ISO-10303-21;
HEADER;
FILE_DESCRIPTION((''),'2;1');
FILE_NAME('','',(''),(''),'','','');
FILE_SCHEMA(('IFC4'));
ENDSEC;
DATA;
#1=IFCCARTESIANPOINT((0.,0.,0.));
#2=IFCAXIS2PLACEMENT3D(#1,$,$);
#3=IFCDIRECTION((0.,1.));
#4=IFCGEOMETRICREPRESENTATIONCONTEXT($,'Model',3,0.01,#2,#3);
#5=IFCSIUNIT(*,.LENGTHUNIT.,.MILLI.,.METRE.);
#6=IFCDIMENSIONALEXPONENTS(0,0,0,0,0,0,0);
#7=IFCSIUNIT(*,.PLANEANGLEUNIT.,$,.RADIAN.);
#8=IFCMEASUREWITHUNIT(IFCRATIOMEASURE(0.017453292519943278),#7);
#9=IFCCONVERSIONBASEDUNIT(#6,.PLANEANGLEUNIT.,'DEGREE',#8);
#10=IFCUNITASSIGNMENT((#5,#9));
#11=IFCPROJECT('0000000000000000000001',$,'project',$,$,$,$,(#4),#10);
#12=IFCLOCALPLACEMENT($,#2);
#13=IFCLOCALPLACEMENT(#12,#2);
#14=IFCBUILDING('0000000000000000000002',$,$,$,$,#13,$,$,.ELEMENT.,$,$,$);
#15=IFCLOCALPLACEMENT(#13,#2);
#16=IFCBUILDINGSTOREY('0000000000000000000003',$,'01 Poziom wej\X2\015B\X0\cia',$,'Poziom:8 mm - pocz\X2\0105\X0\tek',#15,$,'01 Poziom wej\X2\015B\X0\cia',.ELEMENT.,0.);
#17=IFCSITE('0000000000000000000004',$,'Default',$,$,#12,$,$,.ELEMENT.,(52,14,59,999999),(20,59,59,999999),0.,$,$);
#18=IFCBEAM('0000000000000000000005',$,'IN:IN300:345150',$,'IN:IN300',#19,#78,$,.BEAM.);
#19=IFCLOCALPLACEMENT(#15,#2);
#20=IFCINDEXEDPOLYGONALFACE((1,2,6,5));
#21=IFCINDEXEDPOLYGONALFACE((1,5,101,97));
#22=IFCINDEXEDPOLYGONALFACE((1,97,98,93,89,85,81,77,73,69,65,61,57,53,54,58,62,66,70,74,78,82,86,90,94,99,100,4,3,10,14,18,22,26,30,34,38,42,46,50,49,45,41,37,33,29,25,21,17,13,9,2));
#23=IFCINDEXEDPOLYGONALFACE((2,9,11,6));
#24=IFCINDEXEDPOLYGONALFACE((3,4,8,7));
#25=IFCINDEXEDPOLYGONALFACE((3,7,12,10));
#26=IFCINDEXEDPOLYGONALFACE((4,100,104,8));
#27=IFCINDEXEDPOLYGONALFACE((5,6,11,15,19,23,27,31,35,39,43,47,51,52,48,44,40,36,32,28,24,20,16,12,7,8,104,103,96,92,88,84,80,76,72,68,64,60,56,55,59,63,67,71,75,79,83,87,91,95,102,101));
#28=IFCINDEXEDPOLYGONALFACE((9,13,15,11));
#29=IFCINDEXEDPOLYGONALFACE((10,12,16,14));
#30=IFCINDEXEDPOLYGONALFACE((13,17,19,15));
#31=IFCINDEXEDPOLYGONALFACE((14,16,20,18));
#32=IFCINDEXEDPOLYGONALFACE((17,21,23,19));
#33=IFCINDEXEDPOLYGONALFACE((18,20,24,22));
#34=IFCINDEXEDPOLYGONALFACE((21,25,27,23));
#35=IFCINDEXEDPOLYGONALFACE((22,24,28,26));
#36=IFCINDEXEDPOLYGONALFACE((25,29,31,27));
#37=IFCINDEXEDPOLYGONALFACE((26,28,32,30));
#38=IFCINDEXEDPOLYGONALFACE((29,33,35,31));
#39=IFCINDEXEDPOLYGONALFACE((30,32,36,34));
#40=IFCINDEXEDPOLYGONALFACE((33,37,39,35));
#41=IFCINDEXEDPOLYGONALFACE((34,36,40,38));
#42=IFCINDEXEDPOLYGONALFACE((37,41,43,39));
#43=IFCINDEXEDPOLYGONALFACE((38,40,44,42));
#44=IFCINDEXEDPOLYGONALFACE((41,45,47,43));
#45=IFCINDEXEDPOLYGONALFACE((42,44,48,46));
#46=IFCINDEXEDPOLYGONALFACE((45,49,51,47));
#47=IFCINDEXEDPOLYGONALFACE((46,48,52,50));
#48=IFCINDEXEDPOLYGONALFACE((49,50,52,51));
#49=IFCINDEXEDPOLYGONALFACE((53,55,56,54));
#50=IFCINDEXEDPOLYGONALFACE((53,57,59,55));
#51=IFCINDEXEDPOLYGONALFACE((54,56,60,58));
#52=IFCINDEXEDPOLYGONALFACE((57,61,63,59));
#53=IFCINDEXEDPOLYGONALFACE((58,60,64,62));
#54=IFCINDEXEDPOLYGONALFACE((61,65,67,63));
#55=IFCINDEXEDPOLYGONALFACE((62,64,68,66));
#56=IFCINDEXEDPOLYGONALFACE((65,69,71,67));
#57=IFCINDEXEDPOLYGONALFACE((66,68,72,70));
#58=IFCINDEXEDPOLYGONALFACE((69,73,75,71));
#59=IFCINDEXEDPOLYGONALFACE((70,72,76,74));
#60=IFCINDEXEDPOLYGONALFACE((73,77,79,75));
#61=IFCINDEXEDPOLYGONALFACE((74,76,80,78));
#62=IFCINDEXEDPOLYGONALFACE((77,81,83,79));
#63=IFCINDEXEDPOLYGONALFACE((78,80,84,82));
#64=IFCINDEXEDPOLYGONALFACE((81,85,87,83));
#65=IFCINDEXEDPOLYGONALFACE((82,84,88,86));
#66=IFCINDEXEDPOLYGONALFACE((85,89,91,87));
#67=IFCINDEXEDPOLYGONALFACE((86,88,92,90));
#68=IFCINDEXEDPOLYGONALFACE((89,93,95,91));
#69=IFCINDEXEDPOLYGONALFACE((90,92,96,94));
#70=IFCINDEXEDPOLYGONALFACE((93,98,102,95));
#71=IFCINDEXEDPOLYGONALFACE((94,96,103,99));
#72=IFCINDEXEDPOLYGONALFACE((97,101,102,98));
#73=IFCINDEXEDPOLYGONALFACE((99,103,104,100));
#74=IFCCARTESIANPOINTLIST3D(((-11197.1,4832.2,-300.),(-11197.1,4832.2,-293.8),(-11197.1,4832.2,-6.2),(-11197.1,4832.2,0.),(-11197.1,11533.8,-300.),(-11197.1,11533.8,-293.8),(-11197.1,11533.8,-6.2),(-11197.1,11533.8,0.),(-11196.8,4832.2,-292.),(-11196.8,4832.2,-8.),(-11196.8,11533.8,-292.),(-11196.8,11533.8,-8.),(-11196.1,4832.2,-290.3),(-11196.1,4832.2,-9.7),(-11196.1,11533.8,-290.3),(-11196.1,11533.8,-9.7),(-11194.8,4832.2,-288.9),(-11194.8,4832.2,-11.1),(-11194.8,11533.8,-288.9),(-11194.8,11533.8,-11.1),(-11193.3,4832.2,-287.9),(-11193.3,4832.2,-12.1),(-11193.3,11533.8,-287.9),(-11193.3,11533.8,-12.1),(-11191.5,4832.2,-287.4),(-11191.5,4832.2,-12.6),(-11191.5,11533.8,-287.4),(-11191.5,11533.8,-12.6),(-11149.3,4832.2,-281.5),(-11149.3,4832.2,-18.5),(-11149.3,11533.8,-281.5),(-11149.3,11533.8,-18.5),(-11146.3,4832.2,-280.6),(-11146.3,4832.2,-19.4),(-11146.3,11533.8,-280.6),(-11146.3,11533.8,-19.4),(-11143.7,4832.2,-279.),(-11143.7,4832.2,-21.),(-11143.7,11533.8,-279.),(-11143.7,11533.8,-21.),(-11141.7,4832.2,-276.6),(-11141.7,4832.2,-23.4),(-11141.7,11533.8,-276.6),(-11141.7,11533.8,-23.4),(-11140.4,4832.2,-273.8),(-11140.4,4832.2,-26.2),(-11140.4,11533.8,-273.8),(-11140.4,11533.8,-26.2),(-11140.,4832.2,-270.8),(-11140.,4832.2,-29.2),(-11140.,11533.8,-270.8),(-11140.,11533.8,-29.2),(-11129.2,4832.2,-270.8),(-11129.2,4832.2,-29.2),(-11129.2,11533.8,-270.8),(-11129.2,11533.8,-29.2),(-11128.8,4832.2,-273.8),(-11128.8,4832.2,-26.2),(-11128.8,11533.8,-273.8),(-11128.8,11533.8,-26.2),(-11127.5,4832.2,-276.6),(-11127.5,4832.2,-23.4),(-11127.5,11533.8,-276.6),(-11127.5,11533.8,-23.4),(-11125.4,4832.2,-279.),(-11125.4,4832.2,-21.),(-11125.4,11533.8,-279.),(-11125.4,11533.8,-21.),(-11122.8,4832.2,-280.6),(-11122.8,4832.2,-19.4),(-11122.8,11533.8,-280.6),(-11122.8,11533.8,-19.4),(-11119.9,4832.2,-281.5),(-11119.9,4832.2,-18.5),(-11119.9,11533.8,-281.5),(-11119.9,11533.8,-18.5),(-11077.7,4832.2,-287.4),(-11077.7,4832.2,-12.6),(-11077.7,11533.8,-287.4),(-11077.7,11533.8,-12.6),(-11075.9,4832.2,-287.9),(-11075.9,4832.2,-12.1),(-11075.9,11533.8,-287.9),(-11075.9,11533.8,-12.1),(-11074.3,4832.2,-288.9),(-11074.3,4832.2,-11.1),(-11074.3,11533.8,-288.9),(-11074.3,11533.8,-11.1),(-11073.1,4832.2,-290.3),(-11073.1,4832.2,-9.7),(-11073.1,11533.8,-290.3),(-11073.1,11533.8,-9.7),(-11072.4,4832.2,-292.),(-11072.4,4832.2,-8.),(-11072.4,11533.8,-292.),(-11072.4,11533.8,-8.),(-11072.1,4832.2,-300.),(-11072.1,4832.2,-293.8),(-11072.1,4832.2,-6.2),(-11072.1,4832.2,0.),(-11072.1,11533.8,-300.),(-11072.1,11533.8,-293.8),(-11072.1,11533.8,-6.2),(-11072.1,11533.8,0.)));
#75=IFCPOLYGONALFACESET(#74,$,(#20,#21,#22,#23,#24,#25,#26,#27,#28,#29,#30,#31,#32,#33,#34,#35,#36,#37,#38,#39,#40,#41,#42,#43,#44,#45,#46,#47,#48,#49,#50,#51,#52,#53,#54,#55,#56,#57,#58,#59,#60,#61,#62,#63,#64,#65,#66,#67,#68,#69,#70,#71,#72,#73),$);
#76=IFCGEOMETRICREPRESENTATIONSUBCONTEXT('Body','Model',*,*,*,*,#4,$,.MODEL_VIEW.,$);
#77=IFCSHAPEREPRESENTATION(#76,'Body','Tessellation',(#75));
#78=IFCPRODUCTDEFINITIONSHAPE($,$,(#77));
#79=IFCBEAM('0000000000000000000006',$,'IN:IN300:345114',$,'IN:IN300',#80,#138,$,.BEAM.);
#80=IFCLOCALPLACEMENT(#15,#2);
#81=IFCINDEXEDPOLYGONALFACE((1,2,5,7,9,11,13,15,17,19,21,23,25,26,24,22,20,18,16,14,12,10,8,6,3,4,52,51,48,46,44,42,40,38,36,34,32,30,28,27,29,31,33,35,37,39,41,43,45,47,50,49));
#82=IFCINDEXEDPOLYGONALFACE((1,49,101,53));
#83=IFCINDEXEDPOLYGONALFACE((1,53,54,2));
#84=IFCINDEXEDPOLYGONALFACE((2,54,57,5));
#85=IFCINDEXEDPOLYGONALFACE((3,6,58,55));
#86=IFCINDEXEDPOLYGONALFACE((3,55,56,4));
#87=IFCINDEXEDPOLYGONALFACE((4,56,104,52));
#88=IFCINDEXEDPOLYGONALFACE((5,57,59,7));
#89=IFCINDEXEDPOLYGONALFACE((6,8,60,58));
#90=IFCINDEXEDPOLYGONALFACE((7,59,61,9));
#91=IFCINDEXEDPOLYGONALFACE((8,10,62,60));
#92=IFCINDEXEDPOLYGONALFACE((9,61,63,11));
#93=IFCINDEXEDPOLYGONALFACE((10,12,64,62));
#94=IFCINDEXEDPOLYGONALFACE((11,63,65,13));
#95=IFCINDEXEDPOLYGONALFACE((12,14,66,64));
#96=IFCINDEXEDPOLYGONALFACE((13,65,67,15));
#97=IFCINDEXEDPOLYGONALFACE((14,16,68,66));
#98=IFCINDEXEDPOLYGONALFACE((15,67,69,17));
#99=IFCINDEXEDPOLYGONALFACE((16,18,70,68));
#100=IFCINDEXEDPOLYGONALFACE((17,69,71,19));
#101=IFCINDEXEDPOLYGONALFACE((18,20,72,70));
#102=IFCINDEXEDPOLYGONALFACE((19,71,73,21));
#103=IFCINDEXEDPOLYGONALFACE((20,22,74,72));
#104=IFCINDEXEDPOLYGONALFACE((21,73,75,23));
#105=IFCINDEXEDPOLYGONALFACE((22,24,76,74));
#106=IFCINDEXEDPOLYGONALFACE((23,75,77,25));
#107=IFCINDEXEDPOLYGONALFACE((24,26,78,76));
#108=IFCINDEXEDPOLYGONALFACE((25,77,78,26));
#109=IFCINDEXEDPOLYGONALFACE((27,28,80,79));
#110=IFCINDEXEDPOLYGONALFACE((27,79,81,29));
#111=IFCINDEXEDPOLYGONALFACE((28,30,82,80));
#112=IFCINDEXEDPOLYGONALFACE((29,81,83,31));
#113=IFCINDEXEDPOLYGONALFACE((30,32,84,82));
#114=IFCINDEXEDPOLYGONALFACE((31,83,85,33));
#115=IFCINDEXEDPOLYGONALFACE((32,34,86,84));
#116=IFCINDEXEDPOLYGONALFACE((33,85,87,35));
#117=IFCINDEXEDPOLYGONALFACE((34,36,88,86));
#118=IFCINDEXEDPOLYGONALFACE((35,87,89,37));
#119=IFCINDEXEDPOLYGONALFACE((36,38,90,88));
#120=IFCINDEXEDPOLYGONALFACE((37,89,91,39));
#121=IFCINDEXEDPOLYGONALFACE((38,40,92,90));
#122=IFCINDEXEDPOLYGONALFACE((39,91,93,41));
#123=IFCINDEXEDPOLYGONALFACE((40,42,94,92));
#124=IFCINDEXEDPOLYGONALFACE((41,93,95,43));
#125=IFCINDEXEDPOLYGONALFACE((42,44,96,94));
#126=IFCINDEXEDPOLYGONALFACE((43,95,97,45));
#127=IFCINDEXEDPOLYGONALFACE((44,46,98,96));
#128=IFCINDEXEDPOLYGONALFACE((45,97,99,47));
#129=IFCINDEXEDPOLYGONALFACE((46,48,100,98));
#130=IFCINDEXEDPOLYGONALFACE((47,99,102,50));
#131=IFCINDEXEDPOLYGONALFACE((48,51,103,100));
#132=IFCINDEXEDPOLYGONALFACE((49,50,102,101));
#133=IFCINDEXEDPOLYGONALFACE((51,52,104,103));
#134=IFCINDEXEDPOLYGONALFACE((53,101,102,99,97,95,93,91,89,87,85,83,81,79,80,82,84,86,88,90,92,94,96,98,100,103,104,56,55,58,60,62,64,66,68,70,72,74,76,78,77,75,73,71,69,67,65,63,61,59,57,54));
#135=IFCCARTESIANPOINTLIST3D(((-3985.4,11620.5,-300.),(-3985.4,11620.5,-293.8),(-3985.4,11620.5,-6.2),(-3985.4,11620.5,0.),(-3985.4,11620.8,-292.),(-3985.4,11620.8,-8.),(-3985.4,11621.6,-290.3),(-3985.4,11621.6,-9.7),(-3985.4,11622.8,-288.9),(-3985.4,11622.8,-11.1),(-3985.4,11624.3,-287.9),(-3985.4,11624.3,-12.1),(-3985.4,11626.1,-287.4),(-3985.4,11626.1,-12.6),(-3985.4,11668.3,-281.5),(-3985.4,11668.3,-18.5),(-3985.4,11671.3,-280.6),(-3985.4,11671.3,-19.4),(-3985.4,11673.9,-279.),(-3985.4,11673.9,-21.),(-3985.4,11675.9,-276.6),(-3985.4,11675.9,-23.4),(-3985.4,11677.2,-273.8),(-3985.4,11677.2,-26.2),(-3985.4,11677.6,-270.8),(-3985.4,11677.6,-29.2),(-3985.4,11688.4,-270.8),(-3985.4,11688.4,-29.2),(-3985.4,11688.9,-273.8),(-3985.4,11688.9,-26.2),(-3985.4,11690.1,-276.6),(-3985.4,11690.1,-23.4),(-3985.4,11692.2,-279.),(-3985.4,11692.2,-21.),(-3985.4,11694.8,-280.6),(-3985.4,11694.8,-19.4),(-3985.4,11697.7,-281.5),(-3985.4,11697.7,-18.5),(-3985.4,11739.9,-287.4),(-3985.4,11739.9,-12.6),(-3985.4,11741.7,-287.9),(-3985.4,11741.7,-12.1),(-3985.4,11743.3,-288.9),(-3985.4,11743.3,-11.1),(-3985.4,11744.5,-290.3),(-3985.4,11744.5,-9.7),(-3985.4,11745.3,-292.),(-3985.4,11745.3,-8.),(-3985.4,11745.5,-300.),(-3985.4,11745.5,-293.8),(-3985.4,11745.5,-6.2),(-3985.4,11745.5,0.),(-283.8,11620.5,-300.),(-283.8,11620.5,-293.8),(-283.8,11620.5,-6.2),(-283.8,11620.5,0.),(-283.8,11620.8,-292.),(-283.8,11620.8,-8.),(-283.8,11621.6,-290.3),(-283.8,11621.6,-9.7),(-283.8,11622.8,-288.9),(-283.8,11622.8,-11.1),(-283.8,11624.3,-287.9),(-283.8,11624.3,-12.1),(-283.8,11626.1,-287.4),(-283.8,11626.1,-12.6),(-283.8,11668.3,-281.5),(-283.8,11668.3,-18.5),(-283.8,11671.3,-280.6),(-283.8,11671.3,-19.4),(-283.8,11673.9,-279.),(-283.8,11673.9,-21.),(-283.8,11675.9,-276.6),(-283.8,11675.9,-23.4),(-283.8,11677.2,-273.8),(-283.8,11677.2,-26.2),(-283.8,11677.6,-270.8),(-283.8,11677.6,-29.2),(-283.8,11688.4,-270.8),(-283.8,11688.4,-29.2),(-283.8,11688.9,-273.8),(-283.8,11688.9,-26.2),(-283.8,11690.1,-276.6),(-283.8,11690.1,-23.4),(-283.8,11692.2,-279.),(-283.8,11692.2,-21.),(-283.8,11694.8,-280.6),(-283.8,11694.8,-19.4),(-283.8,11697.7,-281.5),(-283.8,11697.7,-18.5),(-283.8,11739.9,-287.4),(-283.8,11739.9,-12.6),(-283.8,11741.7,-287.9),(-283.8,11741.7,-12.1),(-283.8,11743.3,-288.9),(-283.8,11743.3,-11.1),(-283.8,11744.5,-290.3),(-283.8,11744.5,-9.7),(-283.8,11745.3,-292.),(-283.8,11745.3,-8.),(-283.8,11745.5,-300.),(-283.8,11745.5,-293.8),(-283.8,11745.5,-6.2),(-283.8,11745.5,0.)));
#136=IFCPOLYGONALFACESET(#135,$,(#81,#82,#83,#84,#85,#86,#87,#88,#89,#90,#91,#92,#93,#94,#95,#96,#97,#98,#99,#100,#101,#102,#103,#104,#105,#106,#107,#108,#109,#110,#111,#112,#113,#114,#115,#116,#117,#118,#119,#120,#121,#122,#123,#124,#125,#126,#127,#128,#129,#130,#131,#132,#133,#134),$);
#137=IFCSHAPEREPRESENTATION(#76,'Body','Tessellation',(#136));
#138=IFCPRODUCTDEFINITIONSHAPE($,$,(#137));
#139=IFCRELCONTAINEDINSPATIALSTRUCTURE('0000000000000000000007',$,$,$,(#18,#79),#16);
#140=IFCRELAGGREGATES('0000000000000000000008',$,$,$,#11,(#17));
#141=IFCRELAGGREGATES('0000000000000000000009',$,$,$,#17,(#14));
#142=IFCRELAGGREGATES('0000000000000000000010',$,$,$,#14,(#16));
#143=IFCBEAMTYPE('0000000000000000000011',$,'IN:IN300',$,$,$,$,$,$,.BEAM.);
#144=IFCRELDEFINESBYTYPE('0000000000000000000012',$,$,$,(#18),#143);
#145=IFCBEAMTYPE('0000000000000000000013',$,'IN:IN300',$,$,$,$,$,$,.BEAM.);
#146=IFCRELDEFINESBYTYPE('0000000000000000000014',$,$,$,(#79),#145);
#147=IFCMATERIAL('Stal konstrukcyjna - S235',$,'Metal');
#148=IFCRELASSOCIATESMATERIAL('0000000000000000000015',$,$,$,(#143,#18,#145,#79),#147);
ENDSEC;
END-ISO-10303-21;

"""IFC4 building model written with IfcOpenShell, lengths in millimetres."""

from ifc_helpers import new_model, entity, si_unit, converted_unit, direction, frame, origin, place, context, subcontext, project, spatial, line, arc, indexed_curve, outline, extrude, source, transform, mapped, material, type_object, type_shapes, element, save


model = new_model("IFC4")

# Units and contexts
model_context = context("Model", 3, precision=0.01, world=origin(), true_north=direction((0.0, 1.0)))
body_context = subcontext(model_context, "Body", "Model", "MODEL_VIEW")
ifc_project = project(units=[si_unit("LENGTHUNIT", "METRE", prefix="MILLI"), converted_unit("PLANEANGLEUNIT", "DEGREE", entity("IfcRatioMeasure", 0.017453292519943278), si_unit("PLANEANGLEUNIT", "RADIAN"), dimensions=[0, 0, 0, 0, 0, 0, 0])], contexts=[model_context])

# Site, building, storey
site_placement = place(None, origin())
site = spatial("IfcSite", under=ifc_project, at=site_placement, Name="Default", CompositionType="ELEMENT", RefLatitude=(52, 14, 59, 999999), RefLongitude=(20, 59, 59, 999999), RefElevation=0.0)
building_placement = place(site_placement, origin())
building = spatial("IfcBuilding", under=site, at=building_placement, CompositionType="ELEMENT")
storey_placement = place(building_placement, origin())
storey = spatial("IfcBuildingStorey", under=building, at=storey_placement, Name="01 Poziom wejścia", ObjectType="Poziom:8 mm - początek", LongName="01 Poziom wejścia", CompositionType="ELEMENT", Elevation=0.0)

# Beams
ifc_material = material(Name="Stal konstrukcyjna - S235", Category="Metal")
beam_type_1 = type_object("IfcBeamType", Name="IN:IN300", PredefinedType="BEAM", material=ifc_material)
shared_shape_1 = source(origin(), body_context, "Body", "SweptSolid", [
    extrude(outline(indexed_curve([(143.8, -62.5), (150.0, -62.5), (150.0, 62.5), (143.8, 62.5), (139.6, 60.9), (137.4, 56.9), (131.5, 14.7), (127.9, 8.1), (120.8, 5.4), (-120.8, 5.4), (-127.9, 8.1), (-131.5, 14.7), (-137.4, 56.9), (-139.6, 60.9), (-143.8, 62.5), (-150.0, 62.5), (-150.0, -62.5), (-143.8, -62.5), (-139.6, -60.9), (-137.4, -56.9), (-131.5, -14.7), (-127.9, -8.1), (-120.8, -5.4), (120.8, -5.4), (127.9, -8.1), (131.5, -14.7), (137.4, -56.9), (139.6, -60.9)], segments=[line(1, 2, 3, 4), arc(4, 5, 6), line(6, 7), arc(7, 8, 9), line(9, 10), arc(10, 11, 12), line(12, 13), arc(13, 14, 15), line(15, 16, 17, 18), arc(18, 19, 20), line(20, 21), arc(21, 22, 23), line(23, 24), arc(24, 25, 26), line(26, 27), arc(27, 28, 1)], self_intersect=False)), frame((-3350.8, 0.0, 0.0), z_axis=(1.0, 0.0, 0.0), x_axis=(0.0, 0.0, -1.0)), (0.0, 0.0, 1.0), 6701.6),
])
type_shapes(beam_type_1, [shared_shape_1])
for number, where, z_axis, x_axis, name in (
    (1, (-11134.6, 8183.0, -150.0), (0.0, 0.0, 1.0), (0.0, -1.0, 0.0), "IN:IN300:345150"),
):
    element("IfcBeam", number, at=place(storey_placement, frame(where, z_axis=z_axis, x_axis=x_axis)), inside=storey, type_object=beam_type_1, material=ifc_material, Name=name, ObjectType="IN:IN300", PredefinedType="BEAM", context=body_context, shape_type="MappedRepresentation", body=[
        mapped(shared_shape_1, transform((0.0, 0.0, 0.0), scale=1.0)),
    ])
beam_type_2 = type_object("IfcBeamType", Name="IN:IN300", PredefinedType="BEAM", material=ifc_material)
shared_shape_2 = source(origin(), body_context, "Body", "SweptSolid", [
    extrude(outline(indexed_curve([(143.8, -62.5), (150.0, -62.5), (150.0, 62.5), (143.8, 62.5), (139.6, 60.9), (137.4, 56.9), (131.5, 14.7), (127.9, 8.1), (120.8, 5.4), (-120.8, 5.4), (-127.9, 8.1), (-131.5, 14.7), (-137.4, 56.9), (-139.6, 60.9), (-143.8, 62.5), (-150.0, 62.5), (-150.0, -62.5), (-143.8, -62.5), (-139.6, -60.9), (-137.4, -56.9), (-131.5, -14.7), (-127.9, -8.1), (-120.8, -5.4), (120.8, -5.4), (127.9, -8.1), (131.5, -14.7), (137.4, -56.9), (139.6, -60.9)], segments=[line(1, 2, 3, 4), arc(4, 5, 6), line(6, 7), arc(7, 8, 9), line(9, 10), arc(10, 11, 12), line(12, 13), arc(13, 14, 15), line(15, 16, 17, 18), arc(18, 19, 20), line(20, 21), arc(21, 22, 23), line(23, 24), arc(24, 25, 26), line(26, 27), arc(27, 28, 1)], self_intersect=False)), frame((-1850.8, 0.0, 0.0), z_axis=(1.0, 0.0, 0.0), x_axis=(0.0, 0.0, -1.0)), (0.0, 0.0, 1.0), 3701.6),
])
type_shapes(beam_type_2, [shared_shape_2])
for number, where, name in (
    (2, (-2134.6, 11683.0, -150.0), "IN:IN300:345114"),
):
    element("IfcBeam", number, at=place(storey_placement, frame(where)), inside=storey, type_object=beam_type_2, material=ifc_material, Name=name, ObjectType="IN:IN300", PredefinedType="BEAM", context=body_context, shape_type="MappedRepresentation", body=[
        mapped(shared_shape_2, transform((0.0, 0.0, 0.0), scale=1.0)),
    ])

save(model, "model.ifc")
